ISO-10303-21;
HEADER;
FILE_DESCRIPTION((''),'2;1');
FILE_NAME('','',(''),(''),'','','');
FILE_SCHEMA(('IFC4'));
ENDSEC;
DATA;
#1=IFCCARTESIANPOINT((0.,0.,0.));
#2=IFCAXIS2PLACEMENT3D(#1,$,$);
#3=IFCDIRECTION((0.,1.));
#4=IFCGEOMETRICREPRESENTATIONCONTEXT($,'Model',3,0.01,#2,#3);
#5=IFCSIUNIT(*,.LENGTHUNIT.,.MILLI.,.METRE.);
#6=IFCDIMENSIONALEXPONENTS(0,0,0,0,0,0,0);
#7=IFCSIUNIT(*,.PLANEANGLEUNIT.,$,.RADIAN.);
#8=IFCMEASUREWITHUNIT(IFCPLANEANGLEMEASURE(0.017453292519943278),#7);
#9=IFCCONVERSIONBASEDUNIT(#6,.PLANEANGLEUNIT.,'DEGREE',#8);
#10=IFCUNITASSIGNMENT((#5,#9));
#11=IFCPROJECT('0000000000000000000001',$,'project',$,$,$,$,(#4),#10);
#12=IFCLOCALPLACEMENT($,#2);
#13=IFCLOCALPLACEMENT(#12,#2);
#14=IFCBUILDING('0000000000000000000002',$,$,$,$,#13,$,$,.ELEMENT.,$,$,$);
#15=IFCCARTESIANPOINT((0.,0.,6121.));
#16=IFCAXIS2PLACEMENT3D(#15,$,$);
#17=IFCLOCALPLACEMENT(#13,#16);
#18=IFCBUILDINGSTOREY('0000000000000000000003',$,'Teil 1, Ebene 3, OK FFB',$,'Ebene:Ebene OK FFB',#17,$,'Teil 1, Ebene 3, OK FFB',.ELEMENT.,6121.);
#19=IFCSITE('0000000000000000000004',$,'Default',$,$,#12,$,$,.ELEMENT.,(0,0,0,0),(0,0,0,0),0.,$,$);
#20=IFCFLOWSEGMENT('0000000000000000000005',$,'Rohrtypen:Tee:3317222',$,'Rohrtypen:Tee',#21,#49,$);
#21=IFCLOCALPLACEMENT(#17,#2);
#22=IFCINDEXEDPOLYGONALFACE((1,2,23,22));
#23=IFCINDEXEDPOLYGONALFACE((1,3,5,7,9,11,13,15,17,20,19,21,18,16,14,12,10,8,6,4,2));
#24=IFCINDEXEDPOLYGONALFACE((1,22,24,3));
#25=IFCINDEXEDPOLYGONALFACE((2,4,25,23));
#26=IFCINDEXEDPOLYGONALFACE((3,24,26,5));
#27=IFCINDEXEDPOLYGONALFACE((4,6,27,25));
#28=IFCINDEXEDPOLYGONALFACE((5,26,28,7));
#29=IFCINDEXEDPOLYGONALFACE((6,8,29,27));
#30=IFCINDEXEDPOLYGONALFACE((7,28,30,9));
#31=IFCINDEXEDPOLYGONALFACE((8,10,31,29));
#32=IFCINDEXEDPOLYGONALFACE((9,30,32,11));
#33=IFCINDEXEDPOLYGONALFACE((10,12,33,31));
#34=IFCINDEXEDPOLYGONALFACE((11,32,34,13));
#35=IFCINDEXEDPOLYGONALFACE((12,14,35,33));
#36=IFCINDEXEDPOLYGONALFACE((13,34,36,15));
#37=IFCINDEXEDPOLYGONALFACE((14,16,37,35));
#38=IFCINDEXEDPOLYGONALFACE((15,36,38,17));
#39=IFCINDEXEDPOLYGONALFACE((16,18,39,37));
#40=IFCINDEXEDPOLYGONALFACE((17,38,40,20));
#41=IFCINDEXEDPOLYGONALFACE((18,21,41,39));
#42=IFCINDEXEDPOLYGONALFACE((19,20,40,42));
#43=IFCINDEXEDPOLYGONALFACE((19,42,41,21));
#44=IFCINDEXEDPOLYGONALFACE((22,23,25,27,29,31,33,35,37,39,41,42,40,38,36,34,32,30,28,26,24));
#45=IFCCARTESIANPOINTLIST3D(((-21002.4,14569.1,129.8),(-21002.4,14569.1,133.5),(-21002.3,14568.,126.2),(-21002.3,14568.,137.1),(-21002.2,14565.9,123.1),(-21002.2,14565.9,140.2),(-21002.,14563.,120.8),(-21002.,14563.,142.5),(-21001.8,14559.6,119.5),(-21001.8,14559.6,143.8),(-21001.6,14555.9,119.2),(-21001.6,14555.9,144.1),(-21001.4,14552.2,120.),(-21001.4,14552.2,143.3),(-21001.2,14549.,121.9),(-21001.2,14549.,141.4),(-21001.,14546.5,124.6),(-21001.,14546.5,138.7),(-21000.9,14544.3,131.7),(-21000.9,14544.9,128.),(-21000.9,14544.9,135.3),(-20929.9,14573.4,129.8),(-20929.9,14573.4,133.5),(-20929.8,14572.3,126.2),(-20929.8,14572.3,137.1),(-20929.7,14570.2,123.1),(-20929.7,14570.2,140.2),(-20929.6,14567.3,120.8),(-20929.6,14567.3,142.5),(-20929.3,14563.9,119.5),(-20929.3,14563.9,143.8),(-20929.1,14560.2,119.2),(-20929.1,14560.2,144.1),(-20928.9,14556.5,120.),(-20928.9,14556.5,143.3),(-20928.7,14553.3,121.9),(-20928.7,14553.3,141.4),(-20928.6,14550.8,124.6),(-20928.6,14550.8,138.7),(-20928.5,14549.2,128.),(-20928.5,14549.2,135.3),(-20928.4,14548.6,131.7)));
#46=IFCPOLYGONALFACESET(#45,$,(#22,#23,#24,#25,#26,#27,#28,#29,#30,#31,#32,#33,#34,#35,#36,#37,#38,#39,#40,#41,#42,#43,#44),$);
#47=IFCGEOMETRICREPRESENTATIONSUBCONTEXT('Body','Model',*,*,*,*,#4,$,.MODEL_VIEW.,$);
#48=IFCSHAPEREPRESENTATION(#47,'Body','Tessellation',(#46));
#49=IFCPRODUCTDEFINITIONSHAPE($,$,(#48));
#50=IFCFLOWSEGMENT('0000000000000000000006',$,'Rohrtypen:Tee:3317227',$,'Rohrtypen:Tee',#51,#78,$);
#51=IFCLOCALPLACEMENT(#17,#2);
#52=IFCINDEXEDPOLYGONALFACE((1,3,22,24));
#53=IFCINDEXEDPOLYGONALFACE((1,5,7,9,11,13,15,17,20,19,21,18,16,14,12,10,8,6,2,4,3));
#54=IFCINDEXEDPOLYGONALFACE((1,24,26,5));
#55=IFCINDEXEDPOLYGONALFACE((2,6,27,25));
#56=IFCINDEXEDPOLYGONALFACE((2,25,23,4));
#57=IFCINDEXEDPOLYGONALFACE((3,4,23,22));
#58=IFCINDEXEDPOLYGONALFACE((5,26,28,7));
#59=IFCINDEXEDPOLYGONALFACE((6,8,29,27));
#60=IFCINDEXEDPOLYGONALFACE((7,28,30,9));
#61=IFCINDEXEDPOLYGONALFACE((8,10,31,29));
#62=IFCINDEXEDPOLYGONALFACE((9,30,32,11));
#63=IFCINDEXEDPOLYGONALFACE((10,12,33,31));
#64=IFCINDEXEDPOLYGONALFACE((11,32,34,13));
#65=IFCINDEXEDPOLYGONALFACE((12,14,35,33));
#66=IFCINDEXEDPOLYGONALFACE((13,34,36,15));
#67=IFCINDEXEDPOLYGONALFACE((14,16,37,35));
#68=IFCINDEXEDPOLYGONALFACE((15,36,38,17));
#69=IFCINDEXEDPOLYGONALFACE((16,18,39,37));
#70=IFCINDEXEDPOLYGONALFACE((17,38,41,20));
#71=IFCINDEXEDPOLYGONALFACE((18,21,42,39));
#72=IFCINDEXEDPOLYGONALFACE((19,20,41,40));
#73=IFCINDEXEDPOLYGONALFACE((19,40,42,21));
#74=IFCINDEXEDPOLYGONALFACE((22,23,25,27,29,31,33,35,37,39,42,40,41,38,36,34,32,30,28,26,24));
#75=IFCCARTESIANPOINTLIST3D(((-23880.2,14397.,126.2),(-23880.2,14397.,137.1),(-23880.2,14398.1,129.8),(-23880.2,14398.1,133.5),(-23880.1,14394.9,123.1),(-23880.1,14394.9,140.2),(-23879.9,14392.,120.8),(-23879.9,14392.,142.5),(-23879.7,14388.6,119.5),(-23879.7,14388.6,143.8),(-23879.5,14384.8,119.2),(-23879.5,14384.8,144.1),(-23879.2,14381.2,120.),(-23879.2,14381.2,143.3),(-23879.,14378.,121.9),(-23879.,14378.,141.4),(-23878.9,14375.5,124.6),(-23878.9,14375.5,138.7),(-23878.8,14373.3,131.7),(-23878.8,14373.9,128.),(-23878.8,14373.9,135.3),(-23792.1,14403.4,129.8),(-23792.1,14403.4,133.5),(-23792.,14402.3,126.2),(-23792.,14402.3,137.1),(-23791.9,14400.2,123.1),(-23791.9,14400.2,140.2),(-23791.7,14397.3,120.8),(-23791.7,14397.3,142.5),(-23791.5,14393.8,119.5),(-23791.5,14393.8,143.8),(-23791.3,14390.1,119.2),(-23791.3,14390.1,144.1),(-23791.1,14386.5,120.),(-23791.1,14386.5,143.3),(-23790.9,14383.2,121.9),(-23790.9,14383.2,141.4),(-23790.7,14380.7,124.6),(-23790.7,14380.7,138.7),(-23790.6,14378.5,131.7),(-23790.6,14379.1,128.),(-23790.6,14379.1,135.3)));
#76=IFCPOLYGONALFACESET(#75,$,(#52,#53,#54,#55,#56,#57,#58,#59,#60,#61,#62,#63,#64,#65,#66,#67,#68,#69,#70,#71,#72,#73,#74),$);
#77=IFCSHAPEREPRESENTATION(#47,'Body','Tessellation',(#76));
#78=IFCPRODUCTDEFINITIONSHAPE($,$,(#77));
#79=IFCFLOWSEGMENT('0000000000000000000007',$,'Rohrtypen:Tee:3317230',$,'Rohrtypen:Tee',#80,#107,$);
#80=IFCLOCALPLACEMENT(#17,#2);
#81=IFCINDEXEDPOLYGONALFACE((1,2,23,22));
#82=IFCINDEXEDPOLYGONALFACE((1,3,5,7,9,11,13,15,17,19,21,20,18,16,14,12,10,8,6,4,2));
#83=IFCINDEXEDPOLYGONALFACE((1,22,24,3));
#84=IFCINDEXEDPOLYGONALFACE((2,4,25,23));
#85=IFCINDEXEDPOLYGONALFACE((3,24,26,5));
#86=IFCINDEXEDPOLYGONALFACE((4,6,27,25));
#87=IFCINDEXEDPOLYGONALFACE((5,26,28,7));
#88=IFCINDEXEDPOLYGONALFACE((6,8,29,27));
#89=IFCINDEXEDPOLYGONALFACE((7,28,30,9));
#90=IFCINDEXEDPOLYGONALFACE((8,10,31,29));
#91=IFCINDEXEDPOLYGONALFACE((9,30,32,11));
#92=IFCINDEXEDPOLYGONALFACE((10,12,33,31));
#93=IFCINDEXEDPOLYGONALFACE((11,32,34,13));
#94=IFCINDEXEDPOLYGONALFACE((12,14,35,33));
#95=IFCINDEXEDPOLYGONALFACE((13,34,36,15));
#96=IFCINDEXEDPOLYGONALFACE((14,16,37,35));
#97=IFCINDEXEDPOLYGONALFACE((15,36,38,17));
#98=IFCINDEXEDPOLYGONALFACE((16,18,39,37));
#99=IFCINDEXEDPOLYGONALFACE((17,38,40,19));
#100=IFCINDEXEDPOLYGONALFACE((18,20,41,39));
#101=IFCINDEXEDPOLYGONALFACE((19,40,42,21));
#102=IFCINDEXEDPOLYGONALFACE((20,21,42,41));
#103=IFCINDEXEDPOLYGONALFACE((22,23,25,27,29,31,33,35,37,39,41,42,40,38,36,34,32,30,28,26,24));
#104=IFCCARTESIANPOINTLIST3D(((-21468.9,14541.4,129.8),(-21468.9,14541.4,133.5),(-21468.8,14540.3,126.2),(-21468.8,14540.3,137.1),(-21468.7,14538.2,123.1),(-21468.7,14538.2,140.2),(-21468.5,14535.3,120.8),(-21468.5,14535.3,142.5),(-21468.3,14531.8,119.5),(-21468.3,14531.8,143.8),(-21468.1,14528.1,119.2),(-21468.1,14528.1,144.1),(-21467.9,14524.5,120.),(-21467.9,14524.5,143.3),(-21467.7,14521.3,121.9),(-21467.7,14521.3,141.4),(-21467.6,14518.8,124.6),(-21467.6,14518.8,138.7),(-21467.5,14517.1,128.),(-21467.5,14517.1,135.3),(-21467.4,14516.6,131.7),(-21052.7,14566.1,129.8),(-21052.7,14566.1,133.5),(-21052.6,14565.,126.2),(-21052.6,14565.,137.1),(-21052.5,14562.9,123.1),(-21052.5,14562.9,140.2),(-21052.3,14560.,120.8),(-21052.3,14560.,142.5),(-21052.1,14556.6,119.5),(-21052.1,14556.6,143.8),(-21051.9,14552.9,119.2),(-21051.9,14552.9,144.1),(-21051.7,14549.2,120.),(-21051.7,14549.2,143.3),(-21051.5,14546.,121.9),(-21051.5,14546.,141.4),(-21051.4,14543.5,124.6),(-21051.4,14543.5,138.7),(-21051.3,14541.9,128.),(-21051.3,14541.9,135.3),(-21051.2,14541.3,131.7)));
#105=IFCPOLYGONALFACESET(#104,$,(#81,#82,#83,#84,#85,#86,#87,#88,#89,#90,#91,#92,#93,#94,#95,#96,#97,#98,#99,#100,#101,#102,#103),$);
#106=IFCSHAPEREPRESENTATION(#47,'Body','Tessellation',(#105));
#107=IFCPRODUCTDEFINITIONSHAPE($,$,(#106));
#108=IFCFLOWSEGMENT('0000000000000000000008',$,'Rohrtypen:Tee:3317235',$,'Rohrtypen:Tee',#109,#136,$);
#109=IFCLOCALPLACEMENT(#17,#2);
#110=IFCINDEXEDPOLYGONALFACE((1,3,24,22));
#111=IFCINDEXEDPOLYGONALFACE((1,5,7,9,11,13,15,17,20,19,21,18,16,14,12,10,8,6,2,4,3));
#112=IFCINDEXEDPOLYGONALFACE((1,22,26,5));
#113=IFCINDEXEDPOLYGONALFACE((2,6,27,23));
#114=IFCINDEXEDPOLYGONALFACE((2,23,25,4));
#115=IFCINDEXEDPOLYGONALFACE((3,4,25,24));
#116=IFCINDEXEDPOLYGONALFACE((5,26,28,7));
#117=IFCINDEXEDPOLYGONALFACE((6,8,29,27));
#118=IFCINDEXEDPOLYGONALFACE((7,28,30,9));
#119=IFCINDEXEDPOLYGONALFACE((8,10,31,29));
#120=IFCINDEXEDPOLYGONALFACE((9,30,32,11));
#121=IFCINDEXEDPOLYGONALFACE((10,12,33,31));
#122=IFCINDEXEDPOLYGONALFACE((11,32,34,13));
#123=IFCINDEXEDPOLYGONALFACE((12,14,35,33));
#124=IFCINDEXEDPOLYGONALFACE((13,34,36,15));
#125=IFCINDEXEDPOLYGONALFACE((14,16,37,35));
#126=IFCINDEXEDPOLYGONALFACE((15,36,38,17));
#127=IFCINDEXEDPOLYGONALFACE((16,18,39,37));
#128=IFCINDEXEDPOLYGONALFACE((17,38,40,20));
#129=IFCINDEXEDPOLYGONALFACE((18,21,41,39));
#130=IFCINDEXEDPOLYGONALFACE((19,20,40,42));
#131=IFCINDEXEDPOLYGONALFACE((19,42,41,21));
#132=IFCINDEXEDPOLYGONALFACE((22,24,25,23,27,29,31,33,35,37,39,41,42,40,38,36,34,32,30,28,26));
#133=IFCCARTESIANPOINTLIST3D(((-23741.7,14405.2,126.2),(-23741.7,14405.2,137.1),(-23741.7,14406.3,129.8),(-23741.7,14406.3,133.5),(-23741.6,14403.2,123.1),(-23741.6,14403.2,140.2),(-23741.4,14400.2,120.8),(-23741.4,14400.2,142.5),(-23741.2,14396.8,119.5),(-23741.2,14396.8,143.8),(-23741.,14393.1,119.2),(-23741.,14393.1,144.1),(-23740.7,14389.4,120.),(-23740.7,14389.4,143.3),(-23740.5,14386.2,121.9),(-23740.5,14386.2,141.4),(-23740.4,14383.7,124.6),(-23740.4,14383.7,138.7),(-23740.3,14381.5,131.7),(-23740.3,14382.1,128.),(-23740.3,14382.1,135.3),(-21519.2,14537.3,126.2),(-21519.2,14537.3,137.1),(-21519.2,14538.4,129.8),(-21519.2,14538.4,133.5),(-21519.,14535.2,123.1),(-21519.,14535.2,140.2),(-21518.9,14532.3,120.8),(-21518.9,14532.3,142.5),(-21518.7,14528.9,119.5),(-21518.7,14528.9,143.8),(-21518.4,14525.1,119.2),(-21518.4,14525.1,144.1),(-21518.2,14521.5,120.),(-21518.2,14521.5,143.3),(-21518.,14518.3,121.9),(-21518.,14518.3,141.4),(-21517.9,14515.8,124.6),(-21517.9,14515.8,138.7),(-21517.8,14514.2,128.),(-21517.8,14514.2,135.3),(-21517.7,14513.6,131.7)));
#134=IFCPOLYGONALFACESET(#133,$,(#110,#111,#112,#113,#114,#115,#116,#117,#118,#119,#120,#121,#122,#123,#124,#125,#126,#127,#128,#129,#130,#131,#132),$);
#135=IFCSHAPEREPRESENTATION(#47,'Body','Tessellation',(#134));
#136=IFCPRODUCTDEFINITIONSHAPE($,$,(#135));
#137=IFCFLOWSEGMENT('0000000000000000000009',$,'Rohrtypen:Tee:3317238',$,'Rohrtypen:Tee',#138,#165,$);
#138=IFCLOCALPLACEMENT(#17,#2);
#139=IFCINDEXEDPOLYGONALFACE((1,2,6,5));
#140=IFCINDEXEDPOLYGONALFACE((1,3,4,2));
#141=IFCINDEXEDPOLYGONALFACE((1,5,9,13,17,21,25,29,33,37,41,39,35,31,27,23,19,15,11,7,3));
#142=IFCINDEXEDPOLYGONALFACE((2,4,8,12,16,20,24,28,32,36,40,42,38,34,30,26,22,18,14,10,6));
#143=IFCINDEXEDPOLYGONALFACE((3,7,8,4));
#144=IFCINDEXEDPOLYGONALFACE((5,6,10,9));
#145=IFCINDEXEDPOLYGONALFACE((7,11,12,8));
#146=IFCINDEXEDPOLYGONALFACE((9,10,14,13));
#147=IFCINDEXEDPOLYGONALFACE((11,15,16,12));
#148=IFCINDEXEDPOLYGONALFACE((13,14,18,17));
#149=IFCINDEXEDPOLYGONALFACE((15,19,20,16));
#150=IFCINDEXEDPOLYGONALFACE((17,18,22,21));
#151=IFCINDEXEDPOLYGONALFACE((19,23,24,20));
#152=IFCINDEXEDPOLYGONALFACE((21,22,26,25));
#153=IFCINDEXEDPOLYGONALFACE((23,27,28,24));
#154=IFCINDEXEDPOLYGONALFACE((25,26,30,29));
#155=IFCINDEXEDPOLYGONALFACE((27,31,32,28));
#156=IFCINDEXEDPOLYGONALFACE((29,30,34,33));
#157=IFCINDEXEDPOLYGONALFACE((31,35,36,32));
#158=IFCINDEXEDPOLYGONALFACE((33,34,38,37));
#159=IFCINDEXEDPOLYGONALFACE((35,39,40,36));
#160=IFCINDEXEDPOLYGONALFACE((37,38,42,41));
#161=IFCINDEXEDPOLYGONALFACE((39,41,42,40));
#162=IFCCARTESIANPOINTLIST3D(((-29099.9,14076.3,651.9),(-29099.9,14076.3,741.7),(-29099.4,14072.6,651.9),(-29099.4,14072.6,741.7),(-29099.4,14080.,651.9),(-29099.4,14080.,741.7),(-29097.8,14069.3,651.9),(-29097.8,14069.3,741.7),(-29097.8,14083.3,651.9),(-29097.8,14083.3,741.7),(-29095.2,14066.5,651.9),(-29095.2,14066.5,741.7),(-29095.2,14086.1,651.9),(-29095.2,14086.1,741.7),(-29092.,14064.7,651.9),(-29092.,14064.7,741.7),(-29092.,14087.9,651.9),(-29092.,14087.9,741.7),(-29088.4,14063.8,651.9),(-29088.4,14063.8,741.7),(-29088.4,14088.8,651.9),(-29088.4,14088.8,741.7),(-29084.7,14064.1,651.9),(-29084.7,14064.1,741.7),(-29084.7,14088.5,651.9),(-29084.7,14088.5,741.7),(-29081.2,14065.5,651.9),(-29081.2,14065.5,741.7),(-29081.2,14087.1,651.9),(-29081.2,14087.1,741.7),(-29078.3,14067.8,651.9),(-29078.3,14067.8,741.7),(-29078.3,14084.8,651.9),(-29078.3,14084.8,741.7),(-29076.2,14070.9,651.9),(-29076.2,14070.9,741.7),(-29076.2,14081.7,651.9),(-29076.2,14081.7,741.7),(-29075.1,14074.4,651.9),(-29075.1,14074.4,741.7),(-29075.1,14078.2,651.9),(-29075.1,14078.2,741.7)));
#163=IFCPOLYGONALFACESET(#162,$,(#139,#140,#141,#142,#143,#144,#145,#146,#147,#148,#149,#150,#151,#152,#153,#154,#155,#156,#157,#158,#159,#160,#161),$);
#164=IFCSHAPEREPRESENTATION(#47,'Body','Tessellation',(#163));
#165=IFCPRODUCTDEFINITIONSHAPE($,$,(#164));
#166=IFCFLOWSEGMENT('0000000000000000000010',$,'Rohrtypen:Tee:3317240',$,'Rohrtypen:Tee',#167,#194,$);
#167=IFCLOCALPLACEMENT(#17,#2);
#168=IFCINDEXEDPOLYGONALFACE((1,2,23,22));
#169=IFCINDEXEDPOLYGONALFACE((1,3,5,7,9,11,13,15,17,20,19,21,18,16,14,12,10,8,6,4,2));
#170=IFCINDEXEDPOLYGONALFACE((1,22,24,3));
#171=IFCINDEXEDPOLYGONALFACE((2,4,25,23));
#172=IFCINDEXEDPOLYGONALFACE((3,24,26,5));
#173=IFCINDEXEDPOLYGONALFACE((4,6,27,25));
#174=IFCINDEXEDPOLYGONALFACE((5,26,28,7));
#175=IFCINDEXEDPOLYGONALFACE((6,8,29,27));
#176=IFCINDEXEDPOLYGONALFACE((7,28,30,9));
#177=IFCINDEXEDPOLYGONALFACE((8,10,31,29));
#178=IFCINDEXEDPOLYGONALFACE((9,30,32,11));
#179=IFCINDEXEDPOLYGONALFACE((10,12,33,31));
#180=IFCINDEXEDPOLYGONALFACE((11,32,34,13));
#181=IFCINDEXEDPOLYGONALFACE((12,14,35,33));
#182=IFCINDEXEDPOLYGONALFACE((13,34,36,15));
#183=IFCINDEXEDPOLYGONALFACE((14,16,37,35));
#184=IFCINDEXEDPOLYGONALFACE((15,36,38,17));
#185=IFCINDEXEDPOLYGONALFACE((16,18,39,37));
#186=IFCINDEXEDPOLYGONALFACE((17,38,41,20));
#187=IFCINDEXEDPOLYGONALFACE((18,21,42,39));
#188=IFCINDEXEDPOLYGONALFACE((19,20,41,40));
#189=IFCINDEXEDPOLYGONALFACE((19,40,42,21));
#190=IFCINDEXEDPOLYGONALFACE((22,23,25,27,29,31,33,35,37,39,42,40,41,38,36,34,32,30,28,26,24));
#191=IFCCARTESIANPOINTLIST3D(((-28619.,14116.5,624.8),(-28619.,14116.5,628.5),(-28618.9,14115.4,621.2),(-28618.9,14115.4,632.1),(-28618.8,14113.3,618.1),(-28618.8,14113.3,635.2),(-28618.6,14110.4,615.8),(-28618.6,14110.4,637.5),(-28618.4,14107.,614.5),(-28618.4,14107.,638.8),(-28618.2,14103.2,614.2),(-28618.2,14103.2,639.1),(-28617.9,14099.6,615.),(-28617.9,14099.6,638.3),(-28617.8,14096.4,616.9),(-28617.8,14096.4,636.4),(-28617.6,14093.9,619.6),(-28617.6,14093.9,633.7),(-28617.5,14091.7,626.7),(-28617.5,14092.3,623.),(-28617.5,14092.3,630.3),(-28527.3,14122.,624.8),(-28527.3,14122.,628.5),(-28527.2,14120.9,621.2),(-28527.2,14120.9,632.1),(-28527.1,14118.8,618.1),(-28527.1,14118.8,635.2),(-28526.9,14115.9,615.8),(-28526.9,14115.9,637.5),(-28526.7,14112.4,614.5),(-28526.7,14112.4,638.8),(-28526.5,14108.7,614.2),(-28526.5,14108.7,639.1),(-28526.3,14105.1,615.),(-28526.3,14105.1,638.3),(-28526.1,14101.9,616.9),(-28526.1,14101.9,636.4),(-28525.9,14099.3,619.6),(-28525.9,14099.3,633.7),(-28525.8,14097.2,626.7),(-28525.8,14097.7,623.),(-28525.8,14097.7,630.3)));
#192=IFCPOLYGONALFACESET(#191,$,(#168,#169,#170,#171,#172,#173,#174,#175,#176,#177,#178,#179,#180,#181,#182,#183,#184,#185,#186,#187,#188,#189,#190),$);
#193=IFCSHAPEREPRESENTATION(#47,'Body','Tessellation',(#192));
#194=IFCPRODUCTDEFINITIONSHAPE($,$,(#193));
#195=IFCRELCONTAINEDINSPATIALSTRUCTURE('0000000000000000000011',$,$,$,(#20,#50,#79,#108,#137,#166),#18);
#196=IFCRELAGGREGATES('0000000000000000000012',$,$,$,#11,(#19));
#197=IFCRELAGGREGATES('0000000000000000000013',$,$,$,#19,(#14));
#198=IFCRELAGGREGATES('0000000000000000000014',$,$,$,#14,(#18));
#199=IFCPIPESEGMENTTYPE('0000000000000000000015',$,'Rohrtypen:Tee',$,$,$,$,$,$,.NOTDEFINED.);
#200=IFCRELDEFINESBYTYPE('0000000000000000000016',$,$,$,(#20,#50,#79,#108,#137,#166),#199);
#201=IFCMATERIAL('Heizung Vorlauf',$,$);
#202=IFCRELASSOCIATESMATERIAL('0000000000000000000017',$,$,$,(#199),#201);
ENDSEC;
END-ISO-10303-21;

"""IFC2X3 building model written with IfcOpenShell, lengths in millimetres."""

from ifc_helpers import new_model, entity, si_unit, converted_unit, direction, frame, frame_2d, origin, origin_2d_with_axis, place, context, subcontext, project, spatial, circle, extrude, material, type_object, element, save


model = new_model("IFC2X3")

# Units and contexts
model_context = context("Model", 3, precision=0.01, world=origin(), true_north=direction((0.0, 1.0)))
body_context = subcontext(model_context, "Body", "Model", "MODEL_VIEW")
ifc_project = project(units=[si_unit("LENGTHUNIT", "METRE", prefix="MILLI"), converted_unit("PLANEANGLEUNIT", "DEGREE", entity("IfcPlaneAngleMeasure", 0.017453292519943278), si_unit("PLANEANGLEUNIT", "RADIAN"), dimensions=[0, 0, 0, 0, 0, 0, 0])], contexts=[model_context])

# Site, building, storey
site_placement = place(None, origin())
site = spatial("IfcSite", under=ifc_project, at=site_placement, Name="Default", CompositionType="ELEMENT", RefLatitude=(0, 0, 0, 0), RefLongitude=(0, 0, 0, 0), RefElevation=0.0)
building_placement = place(site_placement, origin())
building = spatial("IfcBuilding", under=site, at=building_placement, CompositionType="ELEMENT")
storey_placement = place(building_placement, frame((0.0, 0.0, 6121.0)))
storey = spatial("IfcBuildingStorey", under=building, at=storey_placement, Name="Teil 1, Ebene 3, OK FFB", ObjectType="Ebene:Ebene OK FFB", LongName="Teil 1, Ebene 3, OK FFB", CompositionType="ELEMENT", Elevation=6121.0)

# Flow segments
ifc_material = material(Name="Heizung Vorlauf")
pipe_segment_type = type_object("IfcPipeSegmentType", Name="Rohrtypen:Tee", PredefinedType="NOTDEFINED", material=ifc_material)
flow_segment_1_placement = place(storey_placement, origin())
element("IfcFlowSegment", 1, at=flow_segment_1_placement, inside=storey, type_object=pipe_segment_type, Name="Rohrtypen:Tee:3317222", ObjectType="Rohrtypen:Tee", context=body_context, shape_type="SweptSolid", body=[
    extrude(circle(Radius=12.5, at=frame_2d((0.0, 0.0), x_axis=(1.0, 0.0))), frame((-21001.7, 14556.8, 131.7), z_axis=(0.998239, 0.059319, 0.0), x_axis=(0.059319, -0.998239, 0.0)), (0.0, 0.0, 1.0), 72.6),
])
flow_segment_2_placement = place(storey_placement, origin())
element("IfcFlowSegment", 2, at=flow_segment_2_placement, inside=storey, type_object=pipe_segment_type, Name="Rohrtypen:Tee:3317227", ObjectType="Rohrtypen:Tee", context=body_context, shape_type="SweptSolid", body=[
    extrude(circle(Radius=12.5, at=frame_2d((0.0, 0.0), x_axis=(1.0, 0.0))), frame((-23879.5, 14385.8, 131.7), z_axis=(0.998239, 0.059319, 0.0), x_axis=(0.059319, -0.998239, 0.0)), (0.0, 0.0, 1.0), 88.3),
])
flow_segment_3_placement = place(storey_placement, origin())
element("IfcFlowSegment", 3, at=flow_segment_3_placement, inside=storey, type_object=pipe_segment_type, Name="Rohrtypen:Tee:3317230", ObjectType="Rohrtypen:Tee", context=body_context, shape_type="SweptSolid", body=[
    extrude(circle(Radius=12.5, at=frame_2d((0.0, 0.0), x_axis=(1.0, 0.0))), frame((-21468.2, 14529.1, 131.7), z_axis=(0.998239, 0.059319, 0.0), x_axis=(0.059319, -0.998239, 0.0)), (0.0, 0.0, 1.0), 416.9),
])
flow_segment_4_placement = place(storey_placement, origin())
element("IfcFlowSegment", 4, at=flow_segment_4_placement, inside=storey, type_object=pipe_segment_type, Name="Rohrtypen:Tee:3317235", ObjectType="Rohrtypen:Tee", context=body_context, shape_type="SweptSolid", body=[
    extrude(circle(Radius=12.5, at=origin_2d_with_axis()), frame((-23741.0, 14394.0, 131.7), z_axis=(0.998239, 0.059319, 0.0), x_axis=(0.059319, -0.998239, 0.0)), (0.0, 0.0, 1.0), 2226.4),
])
flow_segment_5_placement = place(storey_placement, origin())
element("IfcFlowSegment", 5, at=flow_segment_5_placement, inside=storey, type_object=pipe_segment_type, Name="Rohrtypen:Tee:3317238", ObjectType="Rohrtypen:Tee", context=body_context, shape_type="SweptSolid", body=[
    extrude(circle(Radius=12.5, at=frame_2d((0.0, 0.0), x_axis=(1.0, 0.0))), frame((-29087.4, 14076.3, 651.9), z_axis=(0.0, 0.0, 1.0), x_axis=(-1.0, 0.0, 0.0)), (0.0, 0.0, 1.0), 89.8),
])
flow_segment_6_placement = place(storey_placement, origin())
element("IfcFlowSegment", 6, at=flow_segment_6_placement, inside=storey, type_object=pipe_segment_type, Name="Rohrtypen:Tee:3317240", ObjectType="Rohrtypen:Tee", context=body_context, shape_type="SweptSolid", body=[
    extrude(circle(Radius=12.5, at=frame_2d((0.0, 0.0), x_axis=(1.0, 0.0))), frame((-28618.2, 14104.2, 626.7), z_axis=(0.998239, 0.059319, 0.0), x_axis=(0.059319, -0.998239, 0.0)), (0.0, 0.0, 1.0), 91.9),
])

save(model, "model.ifc")
